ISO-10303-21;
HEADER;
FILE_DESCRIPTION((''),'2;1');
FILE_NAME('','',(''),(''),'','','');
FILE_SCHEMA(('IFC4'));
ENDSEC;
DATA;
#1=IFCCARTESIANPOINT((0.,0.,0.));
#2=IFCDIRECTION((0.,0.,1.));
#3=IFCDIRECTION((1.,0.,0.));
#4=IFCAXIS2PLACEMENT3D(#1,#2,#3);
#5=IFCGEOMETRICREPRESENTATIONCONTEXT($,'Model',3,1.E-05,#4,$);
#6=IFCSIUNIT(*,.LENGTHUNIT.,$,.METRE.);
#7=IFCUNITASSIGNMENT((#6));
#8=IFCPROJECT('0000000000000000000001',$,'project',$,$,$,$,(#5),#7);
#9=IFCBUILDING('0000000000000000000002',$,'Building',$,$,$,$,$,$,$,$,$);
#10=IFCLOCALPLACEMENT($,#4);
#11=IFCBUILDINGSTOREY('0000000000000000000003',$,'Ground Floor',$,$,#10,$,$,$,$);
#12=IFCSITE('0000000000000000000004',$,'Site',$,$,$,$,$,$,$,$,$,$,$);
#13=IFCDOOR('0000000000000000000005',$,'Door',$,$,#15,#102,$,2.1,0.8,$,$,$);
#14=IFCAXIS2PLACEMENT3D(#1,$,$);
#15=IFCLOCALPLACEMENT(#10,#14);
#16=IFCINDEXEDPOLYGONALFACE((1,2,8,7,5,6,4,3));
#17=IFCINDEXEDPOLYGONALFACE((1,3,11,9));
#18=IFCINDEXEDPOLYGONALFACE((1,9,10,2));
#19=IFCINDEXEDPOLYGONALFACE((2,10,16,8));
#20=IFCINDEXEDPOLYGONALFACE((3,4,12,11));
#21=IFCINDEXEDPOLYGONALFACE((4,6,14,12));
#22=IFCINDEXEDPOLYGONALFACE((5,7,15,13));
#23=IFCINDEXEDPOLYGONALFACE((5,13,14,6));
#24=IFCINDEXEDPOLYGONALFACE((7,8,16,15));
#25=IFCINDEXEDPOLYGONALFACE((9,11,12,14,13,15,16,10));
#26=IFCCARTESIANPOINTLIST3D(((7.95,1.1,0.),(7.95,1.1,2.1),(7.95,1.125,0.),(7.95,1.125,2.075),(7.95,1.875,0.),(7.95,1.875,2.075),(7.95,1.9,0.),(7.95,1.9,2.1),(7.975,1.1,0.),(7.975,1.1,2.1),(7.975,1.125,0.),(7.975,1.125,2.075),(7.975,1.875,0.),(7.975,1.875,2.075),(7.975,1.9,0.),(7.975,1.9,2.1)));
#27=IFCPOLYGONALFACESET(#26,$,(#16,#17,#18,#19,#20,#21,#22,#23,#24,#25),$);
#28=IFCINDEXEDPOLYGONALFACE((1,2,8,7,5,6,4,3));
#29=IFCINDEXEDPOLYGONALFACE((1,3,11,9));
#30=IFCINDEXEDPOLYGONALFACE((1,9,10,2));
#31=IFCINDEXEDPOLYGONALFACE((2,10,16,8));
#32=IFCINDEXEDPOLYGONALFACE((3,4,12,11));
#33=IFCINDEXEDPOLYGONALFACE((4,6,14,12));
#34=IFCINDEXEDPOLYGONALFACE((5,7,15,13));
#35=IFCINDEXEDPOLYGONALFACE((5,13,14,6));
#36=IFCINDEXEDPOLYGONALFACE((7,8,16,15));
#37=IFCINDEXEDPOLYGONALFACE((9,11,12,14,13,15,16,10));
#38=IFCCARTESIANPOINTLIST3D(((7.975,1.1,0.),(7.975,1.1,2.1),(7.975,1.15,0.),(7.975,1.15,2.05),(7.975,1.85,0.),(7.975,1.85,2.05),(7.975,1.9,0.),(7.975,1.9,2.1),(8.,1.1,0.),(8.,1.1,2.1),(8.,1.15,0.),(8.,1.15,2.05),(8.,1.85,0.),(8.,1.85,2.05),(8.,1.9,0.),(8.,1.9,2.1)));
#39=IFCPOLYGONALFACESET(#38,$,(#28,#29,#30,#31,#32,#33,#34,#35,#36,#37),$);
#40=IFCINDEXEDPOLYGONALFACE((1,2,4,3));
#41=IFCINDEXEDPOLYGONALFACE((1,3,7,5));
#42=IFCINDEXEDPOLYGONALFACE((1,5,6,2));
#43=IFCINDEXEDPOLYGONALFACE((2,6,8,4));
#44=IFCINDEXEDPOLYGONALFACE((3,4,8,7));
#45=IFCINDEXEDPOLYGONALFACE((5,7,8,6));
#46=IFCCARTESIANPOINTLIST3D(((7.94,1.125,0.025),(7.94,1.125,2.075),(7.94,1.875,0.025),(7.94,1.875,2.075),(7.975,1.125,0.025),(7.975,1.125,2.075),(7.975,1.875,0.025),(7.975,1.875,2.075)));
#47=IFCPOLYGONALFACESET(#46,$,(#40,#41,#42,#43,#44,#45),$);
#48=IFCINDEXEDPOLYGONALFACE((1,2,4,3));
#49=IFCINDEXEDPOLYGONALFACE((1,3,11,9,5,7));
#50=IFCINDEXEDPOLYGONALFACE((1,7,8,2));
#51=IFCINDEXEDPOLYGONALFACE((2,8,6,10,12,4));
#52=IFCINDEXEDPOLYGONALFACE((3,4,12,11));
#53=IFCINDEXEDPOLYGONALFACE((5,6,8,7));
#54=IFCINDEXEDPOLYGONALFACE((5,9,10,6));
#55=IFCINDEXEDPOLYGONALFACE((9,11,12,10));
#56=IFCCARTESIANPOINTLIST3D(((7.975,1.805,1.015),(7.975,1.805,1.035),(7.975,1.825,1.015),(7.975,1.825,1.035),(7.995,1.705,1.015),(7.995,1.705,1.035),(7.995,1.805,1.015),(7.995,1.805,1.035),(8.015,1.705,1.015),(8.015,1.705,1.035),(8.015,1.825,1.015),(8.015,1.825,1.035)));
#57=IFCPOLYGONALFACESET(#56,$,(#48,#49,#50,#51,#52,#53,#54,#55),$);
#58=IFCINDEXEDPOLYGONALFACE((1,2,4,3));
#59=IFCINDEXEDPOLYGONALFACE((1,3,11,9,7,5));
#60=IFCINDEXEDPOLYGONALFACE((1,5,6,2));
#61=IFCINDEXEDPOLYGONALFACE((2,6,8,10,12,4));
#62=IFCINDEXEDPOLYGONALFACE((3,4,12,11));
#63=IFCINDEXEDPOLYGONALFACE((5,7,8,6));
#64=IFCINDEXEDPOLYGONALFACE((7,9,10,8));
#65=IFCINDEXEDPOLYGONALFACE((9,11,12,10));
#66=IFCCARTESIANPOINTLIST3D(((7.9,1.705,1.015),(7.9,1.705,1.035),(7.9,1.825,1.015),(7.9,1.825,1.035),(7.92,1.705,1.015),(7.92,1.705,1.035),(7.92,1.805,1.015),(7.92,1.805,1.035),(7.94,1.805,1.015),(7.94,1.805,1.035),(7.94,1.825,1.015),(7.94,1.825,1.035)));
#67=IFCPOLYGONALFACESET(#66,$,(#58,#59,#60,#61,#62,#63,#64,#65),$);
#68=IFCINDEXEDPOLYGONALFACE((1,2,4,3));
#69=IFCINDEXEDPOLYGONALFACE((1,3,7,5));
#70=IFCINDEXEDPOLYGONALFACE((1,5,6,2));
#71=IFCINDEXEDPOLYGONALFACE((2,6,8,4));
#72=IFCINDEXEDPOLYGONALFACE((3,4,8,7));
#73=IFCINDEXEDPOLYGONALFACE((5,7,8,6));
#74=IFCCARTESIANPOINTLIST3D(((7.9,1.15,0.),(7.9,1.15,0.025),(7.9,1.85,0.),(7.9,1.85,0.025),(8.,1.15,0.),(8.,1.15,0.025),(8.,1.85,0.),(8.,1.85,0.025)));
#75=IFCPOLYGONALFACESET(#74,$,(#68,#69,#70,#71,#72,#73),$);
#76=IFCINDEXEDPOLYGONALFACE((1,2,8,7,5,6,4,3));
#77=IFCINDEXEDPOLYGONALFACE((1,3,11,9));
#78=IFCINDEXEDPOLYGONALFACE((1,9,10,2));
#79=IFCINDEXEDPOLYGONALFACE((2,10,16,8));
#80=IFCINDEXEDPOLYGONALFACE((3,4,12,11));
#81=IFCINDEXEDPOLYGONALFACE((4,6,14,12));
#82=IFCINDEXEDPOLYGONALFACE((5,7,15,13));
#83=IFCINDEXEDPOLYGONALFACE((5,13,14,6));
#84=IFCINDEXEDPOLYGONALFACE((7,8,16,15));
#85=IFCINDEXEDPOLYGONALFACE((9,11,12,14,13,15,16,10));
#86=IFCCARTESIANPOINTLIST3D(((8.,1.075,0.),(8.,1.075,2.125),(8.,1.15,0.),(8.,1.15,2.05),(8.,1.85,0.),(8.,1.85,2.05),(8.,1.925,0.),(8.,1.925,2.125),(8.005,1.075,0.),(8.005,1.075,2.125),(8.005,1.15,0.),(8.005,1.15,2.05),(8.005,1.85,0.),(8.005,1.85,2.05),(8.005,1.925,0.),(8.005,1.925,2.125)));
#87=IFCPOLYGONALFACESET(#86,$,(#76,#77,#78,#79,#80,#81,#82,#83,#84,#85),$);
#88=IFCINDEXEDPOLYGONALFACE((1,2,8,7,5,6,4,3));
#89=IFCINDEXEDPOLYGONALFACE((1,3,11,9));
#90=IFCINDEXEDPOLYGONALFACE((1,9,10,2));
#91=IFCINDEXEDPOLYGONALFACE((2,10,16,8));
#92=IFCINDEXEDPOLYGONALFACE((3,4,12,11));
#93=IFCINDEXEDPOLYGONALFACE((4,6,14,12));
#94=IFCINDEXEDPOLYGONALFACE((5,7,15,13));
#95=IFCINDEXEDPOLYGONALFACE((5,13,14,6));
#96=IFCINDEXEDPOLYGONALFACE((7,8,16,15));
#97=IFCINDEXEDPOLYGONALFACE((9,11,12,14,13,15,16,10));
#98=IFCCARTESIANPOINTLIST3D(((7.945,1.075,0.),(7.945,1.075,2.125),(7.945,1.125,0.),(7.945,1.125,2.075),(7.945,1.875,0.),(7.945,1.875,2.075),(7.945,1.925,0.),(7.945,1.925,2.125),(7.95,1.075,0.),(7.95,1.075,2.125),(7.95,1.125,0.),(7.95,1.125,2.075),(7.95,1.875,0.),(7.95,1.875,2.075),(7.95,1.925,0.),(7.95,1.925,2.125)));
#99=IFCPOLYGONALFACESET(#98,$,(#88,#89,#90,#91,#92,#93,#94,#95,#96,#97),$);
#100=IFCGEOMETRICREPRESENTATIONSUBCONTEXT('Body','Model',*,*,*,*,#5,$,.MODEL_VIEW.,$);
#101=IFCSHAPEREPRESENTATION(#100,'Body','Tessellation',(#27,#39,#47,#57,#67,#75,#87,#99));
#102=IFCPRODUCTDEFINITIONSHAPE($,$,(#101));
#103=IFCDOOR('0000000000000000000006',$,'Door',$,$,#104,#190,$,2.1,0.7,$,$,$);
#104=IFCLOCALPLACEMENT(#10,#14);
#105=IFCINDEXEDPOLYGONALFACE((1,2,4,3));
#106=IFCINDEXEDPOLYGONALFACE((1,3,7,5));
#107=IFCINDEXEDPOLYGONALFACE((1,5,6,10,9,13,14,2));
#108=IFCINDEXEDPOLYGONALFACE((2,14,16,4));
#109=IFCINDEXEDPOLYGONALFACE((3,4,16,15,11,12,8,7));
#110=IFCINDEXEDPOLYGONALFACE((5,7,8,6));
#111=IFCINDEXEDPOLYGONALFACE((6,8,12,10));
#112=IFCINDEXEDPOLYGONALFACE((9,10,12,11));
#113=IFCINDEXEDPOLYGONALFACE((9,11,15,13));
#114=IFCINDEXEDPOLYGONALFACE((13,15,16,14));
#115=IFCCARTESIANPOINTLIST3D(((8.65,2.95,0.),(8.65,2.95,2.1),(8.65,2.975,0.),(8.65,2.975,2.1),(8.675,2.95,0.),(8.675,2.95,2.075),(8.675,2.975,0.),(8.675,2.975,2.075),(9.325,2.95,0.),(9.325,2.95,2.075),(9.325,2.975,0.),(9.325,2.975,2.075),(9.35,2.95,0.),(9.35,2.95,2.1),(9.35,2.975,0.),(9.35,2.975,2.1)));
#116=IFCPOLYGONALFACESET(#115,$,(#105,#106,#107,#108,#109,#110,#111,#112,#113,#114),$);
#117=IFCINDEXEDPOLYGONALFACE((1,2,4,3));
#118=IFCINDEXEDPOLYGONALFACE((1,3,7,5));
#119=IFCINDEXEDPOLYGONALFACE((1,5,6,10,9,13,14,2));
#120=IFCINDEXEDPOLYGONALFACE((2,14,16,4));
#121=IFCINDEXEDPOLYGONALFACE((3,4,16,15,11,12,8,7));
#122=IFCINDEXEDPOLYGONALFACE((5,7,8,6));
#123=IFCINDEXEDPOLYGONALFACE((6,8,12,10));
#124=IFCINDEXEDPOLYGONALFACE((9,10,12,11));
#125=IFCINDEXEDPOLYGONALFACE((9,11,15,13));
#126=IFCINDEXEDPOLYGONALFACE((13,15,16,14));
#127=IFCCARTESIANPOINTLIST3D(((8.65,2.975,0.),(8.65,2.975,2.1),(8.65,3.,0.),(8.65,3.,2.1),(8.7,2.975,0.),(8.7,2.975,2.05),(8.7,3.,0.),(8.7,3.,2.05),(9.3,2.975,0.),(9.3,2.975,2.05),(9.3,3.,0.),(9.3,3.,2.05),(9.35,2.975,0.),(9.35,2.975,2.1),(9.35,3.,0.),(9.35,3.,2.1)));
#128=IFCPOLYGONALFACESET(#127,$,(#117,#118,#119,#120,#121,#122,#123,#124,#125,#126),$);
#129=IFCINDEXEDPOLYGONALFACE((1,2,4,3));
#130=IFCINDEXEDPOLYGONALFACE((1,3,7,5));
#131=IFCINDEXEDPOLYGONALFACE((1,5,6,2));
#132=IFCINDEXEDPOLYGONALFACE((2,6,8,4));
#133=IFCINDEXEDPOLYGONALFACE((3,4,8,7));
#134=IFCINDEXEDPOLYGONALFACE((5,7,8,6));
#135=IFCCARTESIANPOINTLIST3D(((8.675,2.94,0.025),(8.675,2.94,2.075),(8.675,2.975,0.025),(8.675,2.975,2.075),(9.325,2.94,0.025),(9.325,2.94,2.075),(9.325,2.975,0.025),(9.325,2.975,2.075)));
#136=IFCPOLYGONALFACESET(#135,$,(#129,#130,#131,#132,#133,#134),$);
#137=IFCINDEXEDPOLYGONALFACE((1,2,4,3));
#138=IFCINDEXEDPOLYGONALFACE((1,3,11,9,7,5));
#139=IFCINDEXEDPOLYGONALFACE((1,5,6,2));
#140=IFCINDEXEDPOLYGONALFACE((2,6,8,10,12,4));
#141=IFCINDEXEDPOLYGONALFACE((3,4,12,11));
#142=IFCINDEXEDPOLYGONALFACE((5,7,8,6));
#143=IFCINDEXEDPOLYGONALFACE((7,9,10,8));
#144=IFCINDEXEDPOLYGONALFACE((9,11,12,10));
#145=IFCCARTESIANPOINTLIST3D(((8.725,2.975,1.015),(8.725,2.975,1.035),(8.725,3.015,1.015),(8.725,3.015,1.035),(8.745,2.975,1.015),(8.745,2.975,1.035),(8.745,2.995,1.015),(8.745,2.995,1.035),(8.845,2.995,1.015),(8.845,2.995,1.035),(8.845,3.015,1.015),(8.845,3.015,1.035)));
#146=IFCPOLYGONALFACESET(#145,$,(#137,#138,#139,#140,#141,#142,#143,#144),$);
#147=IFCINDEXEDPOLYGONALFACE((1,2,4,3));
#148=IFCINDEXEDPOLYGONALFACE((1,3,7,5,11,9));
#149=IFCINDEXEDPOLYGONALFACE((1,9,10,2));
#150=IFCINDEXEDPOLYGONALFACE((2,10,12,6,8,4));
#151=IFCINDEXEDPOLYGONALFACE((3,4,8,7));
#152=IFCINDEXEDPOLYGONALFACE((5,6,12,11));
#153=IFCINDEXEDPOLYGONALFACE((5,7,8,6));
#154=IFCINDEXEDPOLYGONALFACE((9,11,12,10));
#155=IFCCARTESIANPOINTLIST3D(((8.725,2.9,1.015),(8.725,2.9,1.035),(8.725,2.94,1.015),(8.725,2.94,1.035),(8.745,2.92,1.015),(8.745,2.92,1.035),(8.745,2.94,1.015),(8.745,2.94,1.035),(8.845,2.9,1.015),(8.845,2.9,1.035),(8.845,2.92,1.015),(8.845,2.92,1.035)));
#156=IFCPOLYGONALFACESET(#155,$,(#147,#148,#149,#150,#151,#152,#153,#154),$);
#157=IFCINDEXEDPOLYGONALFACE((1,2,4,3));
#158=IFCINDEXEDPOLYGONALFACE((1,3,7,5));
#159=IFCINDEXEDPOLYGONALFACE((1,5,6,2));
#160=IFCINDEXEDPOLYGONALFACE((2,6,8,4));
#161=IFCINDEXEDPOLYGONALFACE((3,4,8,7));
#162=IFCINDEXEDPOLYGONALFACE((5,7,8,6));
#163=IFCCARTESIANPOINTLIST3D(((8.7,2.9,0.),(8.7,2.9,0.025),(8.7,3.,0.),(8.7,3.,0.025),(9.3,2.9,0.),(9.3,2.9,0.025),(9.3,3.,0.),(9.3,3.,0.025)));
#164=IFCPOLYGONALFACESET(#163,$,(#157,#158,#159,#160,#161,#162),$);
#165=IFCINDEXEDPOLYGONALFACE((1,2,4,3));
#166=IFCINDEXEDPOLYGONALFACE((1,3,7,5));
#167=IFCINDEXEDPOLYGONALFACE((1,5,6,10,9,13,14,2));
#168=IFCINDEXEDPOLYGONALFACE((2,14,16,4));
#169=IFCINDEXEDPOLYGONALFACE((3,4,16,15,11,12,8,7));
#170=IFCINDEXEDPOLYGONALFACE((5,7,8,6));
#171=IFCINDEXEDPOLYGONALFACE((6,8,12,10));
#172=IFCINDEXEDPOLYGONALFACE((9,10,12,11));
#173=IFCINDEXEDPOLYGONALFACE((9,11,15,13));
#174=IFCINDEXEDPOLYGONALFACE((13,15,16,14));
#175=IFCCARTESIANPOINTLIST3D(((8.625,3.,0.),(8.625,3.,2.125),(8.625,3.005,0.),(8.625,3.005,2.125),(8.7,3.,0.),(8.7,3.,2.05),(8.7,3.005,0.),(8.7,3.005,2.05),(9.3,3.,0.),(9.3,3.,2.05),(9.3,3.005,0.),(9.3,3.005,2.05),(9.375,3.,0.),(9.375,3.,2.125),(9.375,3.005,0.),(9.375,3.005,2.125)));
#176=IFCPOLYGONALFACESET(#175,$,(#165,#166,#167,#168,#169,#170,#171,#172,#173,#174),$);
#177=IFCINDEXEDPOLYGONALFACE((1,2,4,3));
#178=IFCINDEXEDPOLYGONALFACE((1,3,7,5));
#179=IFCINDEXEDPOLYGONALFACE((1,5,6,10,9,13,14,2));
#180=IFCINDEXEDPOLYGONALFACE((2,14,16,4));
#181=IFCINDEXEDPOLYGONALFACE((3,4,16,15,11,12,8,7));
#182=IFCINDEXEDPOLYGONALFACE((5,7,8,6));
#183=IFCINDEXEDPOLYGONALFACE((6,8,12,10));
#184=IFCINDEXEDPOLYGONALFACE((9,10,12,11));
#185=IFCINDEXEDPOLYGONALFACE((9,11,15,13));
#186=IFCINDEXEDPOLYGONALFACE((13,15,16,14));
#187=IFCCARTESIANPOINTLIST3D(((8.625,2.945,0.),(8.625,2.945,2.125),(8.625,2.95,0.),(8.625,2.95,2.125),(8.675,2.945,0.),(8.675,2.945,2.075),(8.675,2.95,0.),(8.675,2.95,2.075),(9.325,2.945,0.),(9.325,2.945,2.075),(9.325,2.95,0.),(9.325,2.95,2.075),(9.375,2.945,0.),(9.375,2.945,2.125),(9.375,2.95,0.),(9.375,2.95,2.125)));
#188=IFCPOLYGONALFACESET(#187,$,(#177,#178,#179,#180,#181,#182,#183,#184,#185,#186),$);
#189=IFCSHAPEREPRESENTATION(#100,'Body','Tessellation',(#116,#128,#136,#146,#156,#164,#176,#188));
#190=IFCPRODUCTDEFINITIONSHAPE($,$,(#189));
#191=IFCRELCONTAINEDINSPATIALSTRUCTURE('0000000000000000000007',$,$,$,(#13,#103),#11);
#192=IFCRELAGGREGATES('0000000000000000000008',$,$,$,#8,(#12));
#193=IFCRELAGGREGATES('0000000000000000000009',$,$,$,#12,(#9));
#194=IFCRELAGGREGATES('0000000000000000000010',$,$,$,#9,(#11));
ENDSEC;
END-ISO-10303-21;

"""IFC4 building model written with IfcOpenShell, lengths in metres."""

from ifc_helpers import new_model, si_unit, frame, origin_with_axes, place, context, subcontext, project, spatial, line, indexed_curve, outline, extrude, element, save


model = new_model("IFC4")

# Units and contexts
model_context = context("Model", 3, precision=1e-05, world=origin_with_axes())
body_context = subcontext(model_context, "Body", "Model", "MODEL_VIEW")
ifc_project = project(units=[si_unit("LENGTHUNIT", "METRE")], contexts=[model_context])

# Site, building, storey
site = spatial("IfcSite", under=ifc_project, Name="Site")
building = spatial("IfcBuilding", under=site, Name="Building")
storey_placement = place(None, origin_with_axes())
storey = spatial("IfcBuildingStorey", under=building, at=storey_placement, Name="Ground Floor")

# Doors
door_1_placement = place(storey_placement, frame((8.0, 1.1, 0.0), z_axis=(0.0, 0.0, 1.0), x_axis=(0.0, 1.0, 0.0)))
element("IfcDoor", 1, at=door_1_placement, inside=storey, Name="Door", OverallHeight=2.1, OverallWidth=0.8, context=body_context, shape_type="SweptSolid", body=[
    extrude(outline(indexed_curve([(0.0, 0.0), (0.0, 2.1), (0.8, 2.1), (0.8, 0.0), (0.775, 0.0), (0.775, 2.075), (0.025, 2.075), (0.025, 0.0)], segments=[line(1, 2, 3, 4, 5, 6, 7, 8, 1)])), frame((0.0, 0.025, 0.0), z_axis=(0.0, -1.0, 0.0), x_axis=(1.0, 0.0, 0.0)), (0.0, 0.0, -1.0), 0.025),
    extrude(outline(indexed_curve([(0.0, 0.0), (0.0, 2.1), (0.8, 2.1), (0.8, 0.0), (0.75, 0.0), (0.75, 2.05), (0.05, 2.05), (0.05, 0.0)], segments=[line(1, 2, 3, 4, 5, 6, 7, 8, 1)])), frame((0.0, 0.0, 0.0), z_axis=(0.0, -1.0, 0.0), x_axis=(1.0, 0.0, 0.0)), (0.0, 0.0, -1.0), 0.025),
    extrude(outline(indexed_curve([(0.0, 0.0), (0.75, 0.0), (0.75, 0.035), (0.0, 0.035)], segments=[line(1, 2, 3, 4, 1)])), frame((0.025, 0.025, 0.025), z_axis=(0.0, 0.0, 1.0), x_axis=(1.0, 0.0, 0.0)), (0.0, 0.0, 1.0), 2.05),
    extrude(outline(indexed_curve([(0.0, 0.0), (0.0, -0.04), (-0.12, -0.04), (-0.12, -0.02), (-0.02, -0.02), (-0.02, 0.0)], segments=[line(1, 2, 3, 4, 5, 6, 1)])), frame((0.725, 0.025, 1.015), z_axis=(0.0, 0.0, 1.0), x_axis=(1.0, 0.0, 0.0)), (0.0, 0.0, 1.0), 0.02),
    extrude(outline(indexed_curve([(0.0, 0.0), (0.0, 0.04), (-0.12, 0.04), (-0.12, 0.02), (-0.02, 0.02), (-0.02, 0.0)], segments=[line(1, 2, 3, 4, 5, 6, 1)])), frame((0.725, 0.06, 1.015), z_axis=(0.0, 0.0, 1.0), x_axis=(1.0, 0.0, 0.0)), (0.0, 0.0, 1.0), 0.02),
    extrude(outline(indexed_curve([(0.0, 0.0), (0.7, 0.0), (0.7, 0.1), (0.0, 0.1)], segments=[line(1, 2, 3, 4, 1)])), frame((0.05, 0.0, 0.0), z_axis=(0.0, 0.0, 1.0), x_axis=(1.0, 0.0, 0.0)), (0.0, 0.0, 1.0), 0.025),
    extrude(outline(indexed_curve([(0.0, 0.0), (0.0, 2.125), (0.85, 2.125), (0.85, 0.0), (0.775, 0.0), (0.775, 2.05), (0.075, 2.05), (0.075, 0.0)], segments=[line(1, 2, 3, 4, 5, 6, 7, 8, 1)])), frame((-0.025, -0.005, 0.0), z_axis=(0.0, -1.0, 0.0), x_axis=(1.0, 0.0, 0.0)), (0.0, 0.0, -1.0), 0.005),
    extrude(outline(indexed_curve([(0.0, 0.0), (0.0, 2.125), (0.85, 2.125), (0.85, 0.0), (0.8, 0.0), (0.8, 2.075), (0.05, 2.075), (0.05, 0.0)], segments=[line(1, 2, 3, 4, 5, 6, 7, 8, 1)])), frame((-0.025, 0.05, 0.0), z_axis=(0.0, -1.0, 0.0), x_axis=(1.0, 0.0, 0.0)), (0.0, 0.0, -1.0), 0.005),
])
door_2_placement = place(storey_placement, frame((9.35, 3.0, 0.0), z_axis=(0.0, 0.0, 1.0), x_axis=(-1.0, 0.0, 0.0)))
element("IfcDoor", 2, at=door_2_placement, inside=storey, Name="Door", OverallHeight=2.1, OverallWidth=0.7, context=body_context, shape_type="SweptSolid", body=[
    extrude(outline(indexed_curve([(0.0, 0.0), (0.0, 2.1), (0.7, 2.1), (0.7, 0.0), (0.675, 0.0), (0.675, 2.075), (0.025, 2.075), (0.025, 0.0)], segments=[line(1, 2, 3, 4, 5, 6, 7, 8, 1)])), frame((0.0, 0.025, 0.0), z_axis=(0.0, -1.0, 0.0), x_axis=(1.0, 0.0, 0.0)), (0.0, 0.0, -1.0), 0.025),
    extrude(outline(indexed_curve([(0.0, 0.0), (0.0, 2.1), (0.7, 2.1), (0.7, 0.0), (0.65, 0.0), (0.65, 2.05), (0.05, 2.05), (0.05, 0.0)], segments=[line(1, 2, 3, 4, 5, 6, 7, 8, 1)])), frame((0.0, 0.0, 0.0), z_axis=(0.0, -1.0, 0.0), x_axis=(1.0, 0.0, 0.0)), (0.0, 0.0, -1.0), 0.025),
    extrude(outline(indexed_curve([(0.0, 0.0), (0.65, 0.0), (0.65, 0.035), (0.0, 0.035)], segments=[line(1, 2, 3, 4, 1)])), frame((0.025, 0.025, 0.025), z_axis=(0.0, 0.0, 1.0), x_axis=(1.0, 0.0, 0.0)), (0.0, 0.0, 1.0), 2.05),
    extrude(outline(indexed_curve([(0.0, 0.0), (0.0, -0.04), (-0.12, -0.04), (-0.12, -0.02), (-0.02, -0.02), (-0.02, 0.0)], segments=[line(1, 2, 3, 4, 5, 6, 1)])), frame((0.625, 0.025, 1.015), z_axis=(0.0, 0.0, 1.0), x_axis=(1.0, 0.0, 0.0)), (0.0, 0.0, 1.0), 0.02),
    extrude(outline(indexed_curve([(0.0, 0.0), (0.0, 0.04), (-0.12, 0.04), (-0.12, 0.02), (-0.02, 0.02), (-0.02, 0.0)], segments=[line(1, 2, 3, 4, 5, 6, 1)])), frame((0.625, 0.06, 1.015), z_axis=(0.0, 0.0, 1.0), x_axis=(1.0, 0.0, 0.0)), (0.0, 0.0, 1.0), 0.02),
    extrude(outline(indexed_curve([(0.0, 0.0), (0.6, 0.0), (0.6, 0.1), (0.0, 0.1)], segments=[line(1, 2, 3, 4, 1)])), frame((0.05, 0.0, 0.0), z_axis=(0.0, 0.0, 1.0), x_axis=(1.0, 0.0, 0.0)), (0.0, 0.0, 1.0), 0.025),
    extrude(outline(indexed_curve([(0.0, 0.0), (0.0, 2.125), (0.75, 2.125), (0.75, 0.0), (0.675, 0.0), (0.675, 2.05), (0.075, 2.05), (0.075, 0.0)], segments=[line(1, 2, 3, 4, 5, 6, 7, 8, 1)])), frame((-0.025, -0.005, 0.0), z_axis=(0.0, -1.0, 0.0), x_axis=(1.0, 0.0, 0.0)), (0.0, 0.0, -1.0), 0.005),
    extrude(outline(indexed_curve([(0.0, 0.0), (0.0, 2.125), (0.75, 2.125), (0.75, 0.0), (0.7, 0.0), (0.7, 2.075), (0.05, 2.075), (0.05, 0.0)], segments=[line(1, 2, 3, 4, 5, 6, 7, 8, 1)])), frame((-0.025, 0.05, 0.0), z_axis=(0.0, -1.0, 0.0), x_axis=(1.0, 0.0, 0.0)), (0.0, 0.0, -1.0), 0.005),
])

save(model, "model.ifc")
